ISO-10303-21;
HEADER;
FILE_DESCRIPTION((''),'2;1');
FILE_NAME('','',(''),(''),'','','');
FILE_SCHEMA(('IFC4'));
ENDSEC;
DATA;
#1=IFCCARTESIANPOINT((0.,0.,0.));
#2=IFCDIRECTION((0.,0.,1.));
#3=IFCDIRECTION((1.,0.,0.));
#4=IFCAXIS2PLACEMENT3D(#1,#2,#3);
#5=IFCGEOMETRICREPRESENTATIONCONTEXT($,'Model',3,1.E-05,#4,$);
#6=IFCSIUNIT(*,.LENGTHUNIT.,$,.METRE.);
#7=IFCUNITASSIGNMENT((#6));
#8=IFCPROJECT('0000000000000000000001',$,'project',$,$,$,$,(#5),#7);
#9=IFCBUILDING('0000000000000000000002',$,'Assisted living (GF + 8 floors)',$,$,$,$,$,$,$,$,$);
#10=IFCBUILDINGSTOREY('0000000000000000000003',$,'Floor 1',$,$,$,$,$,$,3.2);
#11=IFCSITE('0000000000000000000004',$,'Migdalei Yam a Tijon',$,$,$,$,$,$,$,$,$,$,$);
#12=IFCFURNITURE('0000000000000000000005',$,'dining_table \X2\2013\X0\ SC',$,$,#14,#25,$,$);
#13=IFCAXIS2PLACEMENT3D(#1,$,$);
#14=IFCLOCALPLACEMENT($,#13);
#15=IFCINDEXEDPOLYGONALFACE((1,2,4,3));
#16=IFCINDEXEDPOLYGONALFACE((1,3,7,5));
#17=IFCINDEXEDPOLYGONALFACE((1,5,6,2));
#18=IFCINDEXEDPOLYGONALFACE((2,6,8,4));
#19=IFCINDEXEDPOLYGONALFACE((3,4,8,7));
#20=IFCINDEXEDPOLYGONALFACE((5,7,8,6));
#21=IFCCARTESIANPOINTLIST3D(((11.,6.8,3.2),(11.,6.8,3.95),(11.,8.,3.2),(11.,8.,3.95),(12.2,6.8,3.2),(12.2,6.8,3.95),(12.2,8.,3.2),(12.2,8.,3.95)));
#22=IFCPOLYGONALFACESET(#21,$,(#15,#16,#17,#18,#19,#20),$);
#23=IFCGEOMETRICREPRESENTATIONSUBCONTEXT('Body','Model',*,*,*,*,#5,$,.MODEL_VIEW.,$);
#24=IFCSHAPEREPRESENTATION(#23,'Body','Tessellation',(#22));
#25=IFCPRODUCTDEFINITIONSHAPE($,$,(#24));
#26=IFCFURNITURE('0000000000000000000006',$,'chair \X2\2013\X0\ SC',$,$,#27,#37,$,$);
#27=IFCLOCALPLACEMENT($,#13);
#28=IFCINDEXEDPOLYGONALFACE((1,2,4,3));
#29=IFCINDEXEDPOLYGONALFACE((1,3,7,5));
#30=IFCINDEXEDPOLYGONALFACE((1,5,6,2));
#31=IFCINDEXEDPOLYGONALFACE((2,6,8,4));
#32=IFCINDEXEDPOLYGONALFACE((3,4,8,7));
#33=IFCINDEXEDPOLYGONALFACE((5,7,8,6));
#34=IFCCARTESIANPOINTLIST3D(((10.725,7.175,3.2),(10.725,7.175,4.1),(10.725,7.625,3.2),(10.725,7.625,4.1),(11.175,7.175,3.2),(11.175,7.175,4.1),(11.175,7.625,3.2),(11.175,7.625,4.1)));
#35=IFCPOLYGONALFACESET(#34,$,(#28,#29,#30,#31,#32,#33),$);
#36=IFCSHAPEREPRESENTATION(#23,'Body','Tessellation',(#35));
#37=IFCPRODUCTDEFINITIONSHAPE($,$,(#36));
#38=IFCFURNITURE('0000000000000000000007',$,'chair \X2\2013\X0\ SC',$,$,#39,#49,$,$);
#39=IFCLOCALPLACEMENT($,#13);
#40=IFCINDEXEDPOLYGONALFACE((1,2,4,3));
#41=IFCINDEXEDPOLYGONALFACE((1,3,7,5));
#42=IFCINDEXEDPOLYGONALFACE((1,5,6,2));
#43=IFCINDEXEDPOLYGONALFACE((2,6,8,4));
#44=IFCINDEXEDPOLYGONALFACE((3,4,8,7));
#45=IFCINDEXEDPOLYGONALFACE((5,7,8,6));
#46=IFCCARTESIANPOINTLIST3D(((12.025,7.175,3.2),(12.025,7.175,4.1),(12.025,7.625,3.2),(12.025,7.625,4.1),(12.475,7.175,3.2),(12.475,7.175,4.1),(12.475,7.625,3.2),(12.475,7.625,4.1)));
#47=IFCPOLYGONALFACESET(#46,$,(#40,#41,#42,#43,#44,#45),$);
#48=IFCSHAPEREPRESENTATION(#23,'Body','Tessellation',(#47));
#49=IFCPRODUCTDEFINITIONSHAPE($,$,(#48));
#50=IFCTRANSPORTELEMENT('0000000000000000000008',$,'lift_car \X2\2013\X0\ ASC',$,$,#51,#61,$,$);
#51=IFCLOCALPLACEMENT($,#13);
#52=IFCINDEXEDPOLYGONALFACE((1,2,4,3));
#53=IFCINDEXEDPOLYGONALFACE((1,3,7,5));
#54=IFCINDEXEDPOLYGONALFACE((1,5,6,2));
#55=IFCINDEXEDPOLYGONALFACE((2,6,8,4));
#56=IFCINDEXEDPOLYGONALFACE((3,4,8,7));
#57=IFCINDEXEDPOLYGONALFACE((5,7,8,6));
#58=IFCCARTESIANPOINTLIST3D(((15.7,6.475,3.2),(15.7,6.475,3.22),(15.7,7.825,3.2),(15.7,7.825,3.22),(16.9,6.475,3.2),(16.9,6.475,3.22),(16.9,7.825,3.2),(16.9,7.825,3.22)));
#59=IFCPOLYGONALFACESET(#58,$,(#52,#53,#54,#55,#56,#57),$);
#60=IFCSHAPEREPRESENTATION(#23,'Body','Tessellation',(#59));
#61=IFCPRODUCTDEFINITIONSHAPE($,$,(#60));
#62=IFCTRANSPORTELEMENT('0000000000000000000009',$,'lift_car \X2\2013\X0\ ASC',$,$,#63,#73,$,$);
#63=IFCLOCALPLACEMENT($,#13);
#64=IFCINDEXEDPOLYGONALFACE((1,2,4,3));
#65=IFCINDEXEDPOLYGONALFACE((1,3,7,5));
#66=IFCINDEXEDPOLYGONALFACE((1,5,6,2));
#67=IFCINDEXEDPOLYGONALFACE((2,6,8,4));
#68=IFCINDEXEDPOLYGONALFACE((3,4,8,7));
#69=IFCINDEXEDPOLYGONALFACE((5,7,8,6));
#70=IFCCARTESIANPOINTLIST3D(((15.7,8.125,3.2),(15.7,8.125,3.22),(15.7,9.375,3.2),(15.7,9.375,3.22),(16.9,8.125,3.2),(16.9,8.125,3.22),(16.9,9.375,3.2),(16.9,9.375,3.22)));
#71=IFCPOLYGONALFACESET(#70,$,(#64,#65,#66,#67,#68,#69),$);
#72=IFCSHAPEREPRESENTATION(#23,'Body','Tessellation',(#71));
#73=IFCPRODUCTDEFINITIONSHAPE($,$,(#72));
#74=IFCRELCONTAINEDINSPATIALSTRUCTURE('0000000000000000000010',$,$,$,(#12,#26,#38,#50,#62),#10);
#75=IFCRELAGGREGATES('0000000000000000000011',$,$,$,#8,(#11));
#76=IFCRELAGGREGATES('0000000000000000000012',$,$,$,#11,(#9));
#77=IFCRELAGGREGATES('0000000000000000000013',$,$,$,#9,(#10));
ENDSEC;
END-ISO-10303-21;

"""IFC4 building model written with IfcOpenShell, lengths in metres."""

from ifc_helpers import new_model, si_unit, frame, origin_with_axes, context, subcontext, project, spatial, line, indexed_curve, outline, extrude, element, save


model = new_model("IFC4")

# Units and contexts
model_context = context("Model", 3, precision=1e-05, world=origin_with_axes())
body_context = subcontext(model_context, "Body", "Model", "MODEL_VIEW")
ifc_project = project(units=[si_unit("LENGTHUNIT", "METRE")], contexts=[model_context])

# Site, building, storey
site = spatial("IfcSite", under=ifc_project, Name="Migdalei Yam a Tijon")
building = spatial("IfcBuilding", under=site, Name="Assisted living (GF + 8 floors)")
storey = spatial("IfcBuildingStorey", under=building, Name="Floor 1", Elevation=3.2)

# Furniture
element("IfcFurniture", 1, inside=storey, Name="dining_table – SC", context=body_context, shape_type="SweptSolid", body=[
    extrude(outline(indexed_curve([(0.0, 0.0), (1.2, 0.0), (1.2, 1.2), (0.0, 1.2)], segments=[line(1, 2, 3, 4, 1)])), frame((11.0, 6.8, 3.2), z_axis=(0.0, 0.0, 1.0), x_axis=(1.0, 0.0, 0.0)), (0.0, 0.0, 1.0), 0.75),
])
element("IfcFurniture", 2, inside=storey, Name="chair – SC", context=body_context, shape_type="SweptSolid", body=[
    extrude(outline(indexed_curve([(0.0, 0.0), (0.45, 0.0), (0.45, 0.45), (0.0, 0.45)], segments=[line(1, 2, 3, 4, 1)])), frame((10.725, 7.175, 3.2), z_axis=(0.0, 0.0, 1.0), x_axis=(1.0, 0.0, 0.0)), (0.0, 0.0, 1.0), 0.9),
])
element("IfcFurniture", 3, inside=storey, Name="chair – SC", context=body_context, shape_type="SweptSolid", body=[
    extrude(outline(indexed_curve([(0.0, 0.0), (0.45, 0.0), (0.45, 0.45), (0.0, 0.45)], segments=[line(1, 2, 3, 4, 1)])), frame((12.025, 7.175, 3.2), z_axis=(0.0, 0.0, 1.0), x_axis=(1.0, 0.0, 0.0)), (0.0, 0.0, 1.0), 0.9),
])

# Transport elements
element("IfcTransportElement", 4, inside=storey, Name="lift_car – ASC", context=body_context, shape_type="SweptSolid", body=[
    extrude(outline(indexed_curve([(0.0, 0.0), (1.2, 0.0), (1.2, 1.35), (0.0, 1.35)], segments=[line(1, 2, 3, 4, 1)])), frame((15.7, 6.475, 3.2), z_axis=(0.0, 0.0, 1.0), x_axis=(1.0, 0.0, 0.0)), (0.0, 0.0, 1.0), 0.02),
])
element("IfcTransportElement", 5, inside=storey, Name="lift_car – ASC", context=body_context, shape_type="SweptSolid", body=[
    extrude(outline(indexed_curve([(0.0, 0.0), (1.2, 0.0), (1.2, 1.25), (0.0, 1.25)], segments=[line(1, 2, 3, 4, 1)])), frame((15.7, 8.125, 3.2), z_axis=(0.0, 0.0, 1.0), x_axis=(1.0, 0.0, 0.0)), (0.0, 0.0, 1.0), 0.02),
])

save(model, "model.ifc")
